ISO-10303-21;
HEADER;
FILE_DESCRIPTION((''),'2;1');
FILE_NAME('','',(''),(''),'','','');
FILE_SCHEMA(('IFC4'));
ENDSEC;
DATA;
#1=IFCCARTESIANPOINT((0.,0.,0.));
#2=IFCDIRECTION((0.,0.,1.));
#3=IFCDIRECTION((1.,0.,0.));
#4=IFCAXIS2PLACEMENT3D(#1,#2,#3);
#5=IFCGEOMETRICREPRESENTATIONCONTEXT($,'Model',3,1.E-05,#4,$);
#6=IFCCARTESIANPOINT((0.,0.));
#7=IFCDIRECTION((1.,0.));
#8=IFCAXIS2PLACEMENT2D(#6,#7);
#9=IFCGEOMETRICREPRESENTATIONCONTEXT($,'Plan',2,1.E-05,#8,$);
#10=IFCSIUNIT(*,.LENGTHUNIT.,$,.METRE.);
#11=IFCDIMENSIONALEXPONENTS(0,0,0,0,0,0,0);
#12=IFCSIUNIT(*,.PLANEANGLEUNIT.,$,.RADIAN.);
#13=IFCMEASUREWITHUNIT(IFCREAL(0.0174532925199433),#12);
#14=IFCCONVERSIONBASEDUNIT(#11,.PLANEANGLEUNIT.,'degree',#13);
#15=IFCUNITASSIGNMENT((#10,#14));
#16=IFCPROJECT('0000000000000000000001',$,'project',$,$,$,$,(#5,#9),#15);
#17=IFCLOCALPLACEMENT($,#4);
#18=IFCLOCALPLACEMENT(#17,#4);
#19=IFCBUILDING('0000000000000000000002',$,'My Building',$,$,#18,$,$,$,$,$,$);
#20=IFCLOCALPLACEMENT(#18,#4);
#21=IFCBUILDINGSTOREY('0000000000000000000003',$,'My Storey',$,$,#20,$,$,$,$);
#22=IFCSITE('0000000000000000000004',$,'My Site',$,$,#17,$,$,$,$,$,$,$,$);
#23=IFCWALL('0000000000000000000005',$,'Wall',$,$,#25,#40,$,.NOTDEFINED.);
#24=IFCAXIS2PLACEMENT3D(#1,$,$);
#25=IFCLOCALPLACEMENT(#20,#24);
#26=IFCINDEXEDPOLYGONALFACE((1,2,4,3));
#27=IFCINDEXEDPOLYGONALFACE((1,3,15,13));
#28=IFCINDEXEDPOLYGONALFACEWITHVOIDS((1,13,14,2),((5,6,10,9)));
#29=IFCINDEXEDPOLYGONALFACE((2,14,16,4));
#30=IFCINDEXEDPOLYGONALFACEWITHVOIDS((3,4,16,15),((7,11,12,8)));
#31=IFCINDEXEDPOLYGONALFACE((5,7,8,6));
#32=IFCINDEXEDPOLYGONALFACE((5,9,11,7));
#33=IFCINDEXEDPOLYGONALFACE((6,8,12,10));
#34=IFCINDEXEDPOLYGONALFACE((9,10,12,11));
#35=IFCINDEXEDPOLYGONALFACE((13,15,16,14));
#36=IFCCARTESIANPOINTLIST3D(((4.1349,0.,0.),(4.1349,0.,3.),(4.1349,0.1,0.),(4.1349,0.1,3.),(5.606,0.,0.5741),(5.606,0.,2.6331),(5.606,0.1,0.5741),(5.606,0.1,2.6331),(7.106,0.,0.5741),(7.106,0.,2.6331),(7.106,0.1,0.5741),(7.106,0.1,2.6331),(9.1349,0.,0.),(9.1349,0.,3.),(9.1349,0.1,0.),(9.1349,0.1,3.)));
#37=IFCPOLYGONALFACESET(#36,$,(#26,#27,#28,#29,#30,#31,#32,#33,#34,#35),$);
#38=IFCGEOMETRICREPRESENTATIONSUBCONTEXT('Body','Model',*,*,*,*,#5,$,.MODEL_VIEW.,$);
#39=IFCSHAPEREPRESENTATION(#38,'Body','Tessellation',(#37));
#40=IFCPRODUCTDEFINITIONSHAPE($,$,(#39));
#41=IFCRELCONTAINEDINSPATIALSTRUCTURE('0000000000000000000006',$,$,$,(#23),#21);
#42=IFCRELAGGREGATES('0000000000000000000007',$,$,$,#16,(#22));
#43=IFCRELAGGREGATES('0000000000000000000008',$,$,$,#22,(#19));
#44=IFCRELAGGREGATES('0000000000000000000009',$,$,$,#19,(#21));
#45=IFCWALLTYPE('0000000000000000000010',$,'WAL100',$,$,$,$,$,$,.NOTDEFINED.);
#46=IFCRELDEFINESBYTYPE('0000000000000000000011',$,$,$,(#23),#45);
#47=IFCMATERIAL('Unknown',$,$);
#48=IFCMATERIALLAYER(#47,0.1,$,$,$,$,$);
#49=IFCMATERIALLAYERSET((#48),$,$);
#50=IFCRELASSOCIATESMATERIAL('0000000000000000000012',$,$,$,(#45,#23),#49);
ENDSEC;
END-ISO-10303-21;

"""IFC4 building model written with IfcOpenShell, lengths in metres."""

from ifc_helpers import new_model, entity, si_unit, converted_unit, frame, origin_with_axes, origin_2d_with_axis, place, context, subcontext, project, spatial, line, indexed_curve, outline, extrude, source, transform, mapped, material, layer, layer_set, layer_usage, type_object, element, save


model = new_model("IFC4")

# Units and contexts
model_context = context("Model", 3, precision=1e-05, world=origin_with_axes())
plan_context = context("Plan", 2, precision=1e-05, world=origin_2d_with_axis())
body_context = subcontext(model_context, "Body", "Model", "MODEL_VIEW")
ifc_project = project(units=[si_unit("LENGTHUNIT", "METRE"), converted_unit("PLANEANGLEUNIT", "degree", entity("IfcReal", 0.0174532925199433), si_unit("PLANEANGLEUNIT", "RADIAN"), dimensions=[0, 0, 0, 0, 0, 0, 0])], contexts=[model_context, plan_context])

# Site, building, storey
site_placement = place(None, origin_with_axes())
site = spatial("IfcSite", under=ifc_project, at=site_placement, Name="My Site")
building_placement = place(site_placement, origin_with_axes())
building = spatial("IfcBuilding", under=site, at=building_placement, Name="My Building")
storey_placement = place(building_placement, origin_with_axes())
storey = spatial("IfcBuildingStorey", under=building, at=storey_placement, Name="My Storey")

# Wall, opening
ifc_material = material(Name="Unknown")
ifc_layer = layer(ifc_material, 0.1)
ifc_layer_set = layer_set([ifc_layer])
ifc_layer_usage = layer_usage(ifc_layer_set, "AXIS2", "POSITIVE", 0.0)
wall_type = type_object("IfcWallType", Name="WAL100", PredefinedType="NOTDEFINED", material=ifc_layer_set)
wall_placement = place(storey_placement, frame((4.1349, 0.0, 0.0), z_axis=(0.0, 0.0, 1.0), x_axis=(1.0, 0.0, 0.0)))
wall = element("IfcWall", 1, at=wall_placement, inside=storey, type_object=wall_type, material=ifc_layer_usage, Name="Wall", PredefinedType="NOTDEFINED", context=body_context, shape_type="SweptSolid", body=[
    extrude(outline(indexed_curve([(0.0, 0.0), (0.0, 0.1), (5.0, 0.1), (5.0, 0.0), (0.0, 0.0)], self_intersect=False)), origin_with_axes(), (0.0, 0.0, 1.0), 3.0),
])
shared_shape = source(origin_with_axes(), body_context, "Body", "SweptSolid", [
    extrude(outline(indexed_curve([(0.0, 0.0, 0.0), (1.5, 0.0, 0.0), (1.5, 0.0, 2.059), (0.0, 0.0, 2.059)], segments=[line(1, 2), line(2, 3), line(3, 4), line(4, 1)])), frame((0.0, -0.1, 0.0), z_axis=(0.0, 0.0, 1.0), x_axis=(1.0, 0.0, 0.0)), (0.0, 1.0, 0.0), 0.3),
])
opening_placement = place(wall_placement, frame((1.4711, 0.0, 0.5741), z_axis=(0.0, 0.0, 1.0), x_axis=(1.0, 0.0, 0.0)))
element("IfcOpeningElement", 2, at=opening_placement, cuts=wall, PredefinedType="OPENING", context=body_context, shape_type="MappedRepresentation", body=[
    mapped(shared_shape, transform((0.0, 0.0, 0.0), x_axis=(1.0, 0.0, 0.0), y_axis=(0.0, 1.0, 0.0), z_axis=(0.0, 0.0, 1.0), scale=1.0)),
])

save(model, "model.ifc")
